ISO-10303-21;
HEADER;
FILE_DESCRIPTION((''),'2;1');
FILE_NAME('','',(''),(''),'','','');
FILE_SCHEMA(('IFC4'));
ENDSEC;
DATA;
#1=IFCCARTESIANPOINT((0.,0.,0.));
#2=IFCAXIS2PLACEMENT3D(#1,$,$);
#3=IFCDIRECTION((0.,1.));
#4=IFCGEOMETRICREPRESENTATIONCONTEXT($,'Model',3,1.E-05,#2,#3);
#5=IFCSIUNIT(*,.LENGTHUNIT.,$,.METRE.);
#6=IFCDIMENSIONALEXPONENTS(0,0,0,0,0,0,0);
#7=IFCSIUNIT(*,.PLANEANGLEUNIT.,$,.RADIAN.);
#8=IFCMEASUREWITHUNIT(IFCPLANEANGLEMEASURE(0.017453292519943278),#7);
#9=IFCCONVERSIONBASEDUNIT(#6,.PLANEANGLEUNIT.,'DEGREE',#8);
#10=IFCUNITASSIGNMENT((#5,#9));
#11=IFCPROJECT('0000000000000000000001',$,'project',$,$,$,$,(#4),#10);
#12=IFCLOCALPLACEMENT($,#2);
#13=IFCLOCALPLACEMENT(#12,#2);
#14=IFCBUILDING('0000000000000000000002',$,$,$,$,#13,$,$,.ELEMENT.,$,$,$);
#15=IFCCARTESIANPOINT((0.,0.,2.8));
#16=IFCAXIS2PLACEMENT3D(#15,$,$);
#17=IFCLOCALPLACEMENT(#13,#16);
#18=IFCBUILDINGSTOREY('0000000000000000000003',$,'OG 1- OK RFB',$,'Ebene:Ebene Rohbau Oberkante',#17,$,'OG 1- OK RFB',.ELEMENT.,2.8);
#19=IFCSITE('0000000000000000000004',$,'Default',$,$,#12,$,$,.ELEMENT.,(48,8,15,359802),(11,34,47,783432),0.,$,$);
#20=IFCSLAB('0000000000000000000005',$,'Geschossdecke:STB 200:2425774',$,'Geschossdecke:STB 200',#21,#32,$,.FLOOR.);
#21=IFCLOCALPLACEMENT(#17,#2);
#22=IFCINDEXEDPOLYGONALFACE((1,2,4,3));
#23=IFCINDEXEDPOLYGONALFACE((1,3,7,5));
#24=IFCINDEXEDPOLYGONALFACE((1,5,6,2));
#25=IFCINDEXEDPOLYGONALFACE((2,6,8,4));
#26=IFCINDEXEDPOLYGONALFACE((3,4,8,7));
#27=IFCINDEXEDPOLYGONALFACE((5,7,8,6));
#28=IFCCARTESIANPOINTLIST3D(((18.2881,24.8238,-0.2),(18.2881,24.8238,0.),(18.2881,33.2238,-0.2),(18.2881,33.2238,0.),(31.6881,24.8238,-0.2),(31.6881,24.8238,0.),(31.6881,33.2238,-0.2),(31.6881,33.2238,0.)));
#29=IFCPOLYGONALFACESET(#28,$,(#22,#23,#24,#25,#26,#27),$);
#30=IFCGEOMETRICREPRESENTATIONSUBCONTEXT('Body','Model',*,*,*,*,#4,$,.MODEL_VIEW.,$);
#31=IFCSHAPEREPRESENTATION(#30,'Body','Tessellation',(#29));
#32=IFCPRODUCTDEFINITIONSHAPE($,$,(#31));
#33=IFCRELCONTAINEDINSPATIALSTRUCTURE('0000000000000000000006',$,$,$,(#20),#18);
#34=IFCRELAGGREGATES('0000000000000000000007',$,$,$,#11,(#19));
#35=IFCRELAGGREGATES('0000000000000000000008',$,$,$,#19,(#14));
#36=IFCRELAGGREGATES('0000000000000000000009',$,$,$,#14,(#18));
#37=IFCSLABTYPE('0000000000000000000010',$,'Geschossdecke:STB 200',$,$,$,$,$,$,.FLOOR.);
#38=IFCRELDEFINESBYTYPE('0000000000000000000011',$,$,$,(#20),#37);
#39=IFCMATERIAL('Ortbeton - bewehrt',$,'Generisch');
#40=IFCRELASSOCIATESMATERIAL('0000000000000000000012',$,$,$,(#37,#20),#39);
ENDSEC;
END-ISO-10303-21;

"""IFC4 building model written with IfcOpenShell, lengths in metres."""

from ifc_helpers import new_model, entity, si_unit, converted_unit, direction, frame, origin, place, context, subcontext, project, spatial, indexed_curve, outline, extrude, material, type_object, element, save


model = new_model("IFC4")

# Units and contexts
model_context = context("Model", 3, precision=1e-05, world=origin(), true_north=direction((0.0, 1.0)))
body_context = subcontext(model_context, "Body", "Model", "MODEL_VIEW")
ifc_project = project(units=[si_unit("LENGTHUNIT", "METRE"), converted_unit("PLANEANGLEUNIT", "DEGREE", entity("IfcPlaneAngleMeasure", 0.017453292519943278), si_unit("PLANEANGLEUNIT", "RADIAN"), dimensions=[0, 0, 0, 0, 0, 0, 0])], contexts=[model_context])

# Site, building, storey
site_placement = place(None, origin())
site = spatial("IfcSite", under=ifc_project, at=site_placement, Name="Default", CompositionType="ELEMENT", RefLatitude=(48, 8, 15, 359802), RefLongitude=(11, 34, 47, 783432), RefElevation=0.0)
building_placement = place(site_placement, origin())
building = spatial("IfcBuilding", under=site, at=building_placement, CompositionType="ELEMENT")
storey_placement = place(building_placement, frame((0.0, 0.0, 2.8)))
storey = spatial("IfcBuildingStorey", under=building, at=storey_placement, Name="OG 1- OK RFB", ObjectType="Ebene:Ebene Rohbau Oberkante", LongName="OG 1- OK RFB", CompositionType="ELEMENT", Elevation=2.8)

# Slab
ifc_material = material(Name="Ortbeton - bewehrt", Category="Generisch")
slab_type = type_object("IfcSlabType", Name="Geschossdecke:STB 200", PredefinedType="FLOOR", material=ifc_material)
slab_placement = place(storey_placement, origin())
element("IfcSlab", 1, at=slab_placement, inside=storey, type_object=slab_type, material=ifc_material, Name="Geschossdecke:STB 200:2425774", ObjectType="Geschossdecke:STB 200", PredefinedType="FLOOR", context=body_context, shape_type="SweptSolid", body=[
    extrude(outline(indexed_curve([(-4.2, -6.7), (4.2, -6.7), (4.2, 6.7), (-4.2, 6.7), (-4.2, -6.7)], self_intersect=False)), frame((24.9881, 29.0238, 0.0), z_axis=(0.0, 0.0, -1.0), x_axis=(0.0, 1.0, 0.0)), (0.0, 0.0, 1.0), 0.2),
])

save(model, "model.ifc")
